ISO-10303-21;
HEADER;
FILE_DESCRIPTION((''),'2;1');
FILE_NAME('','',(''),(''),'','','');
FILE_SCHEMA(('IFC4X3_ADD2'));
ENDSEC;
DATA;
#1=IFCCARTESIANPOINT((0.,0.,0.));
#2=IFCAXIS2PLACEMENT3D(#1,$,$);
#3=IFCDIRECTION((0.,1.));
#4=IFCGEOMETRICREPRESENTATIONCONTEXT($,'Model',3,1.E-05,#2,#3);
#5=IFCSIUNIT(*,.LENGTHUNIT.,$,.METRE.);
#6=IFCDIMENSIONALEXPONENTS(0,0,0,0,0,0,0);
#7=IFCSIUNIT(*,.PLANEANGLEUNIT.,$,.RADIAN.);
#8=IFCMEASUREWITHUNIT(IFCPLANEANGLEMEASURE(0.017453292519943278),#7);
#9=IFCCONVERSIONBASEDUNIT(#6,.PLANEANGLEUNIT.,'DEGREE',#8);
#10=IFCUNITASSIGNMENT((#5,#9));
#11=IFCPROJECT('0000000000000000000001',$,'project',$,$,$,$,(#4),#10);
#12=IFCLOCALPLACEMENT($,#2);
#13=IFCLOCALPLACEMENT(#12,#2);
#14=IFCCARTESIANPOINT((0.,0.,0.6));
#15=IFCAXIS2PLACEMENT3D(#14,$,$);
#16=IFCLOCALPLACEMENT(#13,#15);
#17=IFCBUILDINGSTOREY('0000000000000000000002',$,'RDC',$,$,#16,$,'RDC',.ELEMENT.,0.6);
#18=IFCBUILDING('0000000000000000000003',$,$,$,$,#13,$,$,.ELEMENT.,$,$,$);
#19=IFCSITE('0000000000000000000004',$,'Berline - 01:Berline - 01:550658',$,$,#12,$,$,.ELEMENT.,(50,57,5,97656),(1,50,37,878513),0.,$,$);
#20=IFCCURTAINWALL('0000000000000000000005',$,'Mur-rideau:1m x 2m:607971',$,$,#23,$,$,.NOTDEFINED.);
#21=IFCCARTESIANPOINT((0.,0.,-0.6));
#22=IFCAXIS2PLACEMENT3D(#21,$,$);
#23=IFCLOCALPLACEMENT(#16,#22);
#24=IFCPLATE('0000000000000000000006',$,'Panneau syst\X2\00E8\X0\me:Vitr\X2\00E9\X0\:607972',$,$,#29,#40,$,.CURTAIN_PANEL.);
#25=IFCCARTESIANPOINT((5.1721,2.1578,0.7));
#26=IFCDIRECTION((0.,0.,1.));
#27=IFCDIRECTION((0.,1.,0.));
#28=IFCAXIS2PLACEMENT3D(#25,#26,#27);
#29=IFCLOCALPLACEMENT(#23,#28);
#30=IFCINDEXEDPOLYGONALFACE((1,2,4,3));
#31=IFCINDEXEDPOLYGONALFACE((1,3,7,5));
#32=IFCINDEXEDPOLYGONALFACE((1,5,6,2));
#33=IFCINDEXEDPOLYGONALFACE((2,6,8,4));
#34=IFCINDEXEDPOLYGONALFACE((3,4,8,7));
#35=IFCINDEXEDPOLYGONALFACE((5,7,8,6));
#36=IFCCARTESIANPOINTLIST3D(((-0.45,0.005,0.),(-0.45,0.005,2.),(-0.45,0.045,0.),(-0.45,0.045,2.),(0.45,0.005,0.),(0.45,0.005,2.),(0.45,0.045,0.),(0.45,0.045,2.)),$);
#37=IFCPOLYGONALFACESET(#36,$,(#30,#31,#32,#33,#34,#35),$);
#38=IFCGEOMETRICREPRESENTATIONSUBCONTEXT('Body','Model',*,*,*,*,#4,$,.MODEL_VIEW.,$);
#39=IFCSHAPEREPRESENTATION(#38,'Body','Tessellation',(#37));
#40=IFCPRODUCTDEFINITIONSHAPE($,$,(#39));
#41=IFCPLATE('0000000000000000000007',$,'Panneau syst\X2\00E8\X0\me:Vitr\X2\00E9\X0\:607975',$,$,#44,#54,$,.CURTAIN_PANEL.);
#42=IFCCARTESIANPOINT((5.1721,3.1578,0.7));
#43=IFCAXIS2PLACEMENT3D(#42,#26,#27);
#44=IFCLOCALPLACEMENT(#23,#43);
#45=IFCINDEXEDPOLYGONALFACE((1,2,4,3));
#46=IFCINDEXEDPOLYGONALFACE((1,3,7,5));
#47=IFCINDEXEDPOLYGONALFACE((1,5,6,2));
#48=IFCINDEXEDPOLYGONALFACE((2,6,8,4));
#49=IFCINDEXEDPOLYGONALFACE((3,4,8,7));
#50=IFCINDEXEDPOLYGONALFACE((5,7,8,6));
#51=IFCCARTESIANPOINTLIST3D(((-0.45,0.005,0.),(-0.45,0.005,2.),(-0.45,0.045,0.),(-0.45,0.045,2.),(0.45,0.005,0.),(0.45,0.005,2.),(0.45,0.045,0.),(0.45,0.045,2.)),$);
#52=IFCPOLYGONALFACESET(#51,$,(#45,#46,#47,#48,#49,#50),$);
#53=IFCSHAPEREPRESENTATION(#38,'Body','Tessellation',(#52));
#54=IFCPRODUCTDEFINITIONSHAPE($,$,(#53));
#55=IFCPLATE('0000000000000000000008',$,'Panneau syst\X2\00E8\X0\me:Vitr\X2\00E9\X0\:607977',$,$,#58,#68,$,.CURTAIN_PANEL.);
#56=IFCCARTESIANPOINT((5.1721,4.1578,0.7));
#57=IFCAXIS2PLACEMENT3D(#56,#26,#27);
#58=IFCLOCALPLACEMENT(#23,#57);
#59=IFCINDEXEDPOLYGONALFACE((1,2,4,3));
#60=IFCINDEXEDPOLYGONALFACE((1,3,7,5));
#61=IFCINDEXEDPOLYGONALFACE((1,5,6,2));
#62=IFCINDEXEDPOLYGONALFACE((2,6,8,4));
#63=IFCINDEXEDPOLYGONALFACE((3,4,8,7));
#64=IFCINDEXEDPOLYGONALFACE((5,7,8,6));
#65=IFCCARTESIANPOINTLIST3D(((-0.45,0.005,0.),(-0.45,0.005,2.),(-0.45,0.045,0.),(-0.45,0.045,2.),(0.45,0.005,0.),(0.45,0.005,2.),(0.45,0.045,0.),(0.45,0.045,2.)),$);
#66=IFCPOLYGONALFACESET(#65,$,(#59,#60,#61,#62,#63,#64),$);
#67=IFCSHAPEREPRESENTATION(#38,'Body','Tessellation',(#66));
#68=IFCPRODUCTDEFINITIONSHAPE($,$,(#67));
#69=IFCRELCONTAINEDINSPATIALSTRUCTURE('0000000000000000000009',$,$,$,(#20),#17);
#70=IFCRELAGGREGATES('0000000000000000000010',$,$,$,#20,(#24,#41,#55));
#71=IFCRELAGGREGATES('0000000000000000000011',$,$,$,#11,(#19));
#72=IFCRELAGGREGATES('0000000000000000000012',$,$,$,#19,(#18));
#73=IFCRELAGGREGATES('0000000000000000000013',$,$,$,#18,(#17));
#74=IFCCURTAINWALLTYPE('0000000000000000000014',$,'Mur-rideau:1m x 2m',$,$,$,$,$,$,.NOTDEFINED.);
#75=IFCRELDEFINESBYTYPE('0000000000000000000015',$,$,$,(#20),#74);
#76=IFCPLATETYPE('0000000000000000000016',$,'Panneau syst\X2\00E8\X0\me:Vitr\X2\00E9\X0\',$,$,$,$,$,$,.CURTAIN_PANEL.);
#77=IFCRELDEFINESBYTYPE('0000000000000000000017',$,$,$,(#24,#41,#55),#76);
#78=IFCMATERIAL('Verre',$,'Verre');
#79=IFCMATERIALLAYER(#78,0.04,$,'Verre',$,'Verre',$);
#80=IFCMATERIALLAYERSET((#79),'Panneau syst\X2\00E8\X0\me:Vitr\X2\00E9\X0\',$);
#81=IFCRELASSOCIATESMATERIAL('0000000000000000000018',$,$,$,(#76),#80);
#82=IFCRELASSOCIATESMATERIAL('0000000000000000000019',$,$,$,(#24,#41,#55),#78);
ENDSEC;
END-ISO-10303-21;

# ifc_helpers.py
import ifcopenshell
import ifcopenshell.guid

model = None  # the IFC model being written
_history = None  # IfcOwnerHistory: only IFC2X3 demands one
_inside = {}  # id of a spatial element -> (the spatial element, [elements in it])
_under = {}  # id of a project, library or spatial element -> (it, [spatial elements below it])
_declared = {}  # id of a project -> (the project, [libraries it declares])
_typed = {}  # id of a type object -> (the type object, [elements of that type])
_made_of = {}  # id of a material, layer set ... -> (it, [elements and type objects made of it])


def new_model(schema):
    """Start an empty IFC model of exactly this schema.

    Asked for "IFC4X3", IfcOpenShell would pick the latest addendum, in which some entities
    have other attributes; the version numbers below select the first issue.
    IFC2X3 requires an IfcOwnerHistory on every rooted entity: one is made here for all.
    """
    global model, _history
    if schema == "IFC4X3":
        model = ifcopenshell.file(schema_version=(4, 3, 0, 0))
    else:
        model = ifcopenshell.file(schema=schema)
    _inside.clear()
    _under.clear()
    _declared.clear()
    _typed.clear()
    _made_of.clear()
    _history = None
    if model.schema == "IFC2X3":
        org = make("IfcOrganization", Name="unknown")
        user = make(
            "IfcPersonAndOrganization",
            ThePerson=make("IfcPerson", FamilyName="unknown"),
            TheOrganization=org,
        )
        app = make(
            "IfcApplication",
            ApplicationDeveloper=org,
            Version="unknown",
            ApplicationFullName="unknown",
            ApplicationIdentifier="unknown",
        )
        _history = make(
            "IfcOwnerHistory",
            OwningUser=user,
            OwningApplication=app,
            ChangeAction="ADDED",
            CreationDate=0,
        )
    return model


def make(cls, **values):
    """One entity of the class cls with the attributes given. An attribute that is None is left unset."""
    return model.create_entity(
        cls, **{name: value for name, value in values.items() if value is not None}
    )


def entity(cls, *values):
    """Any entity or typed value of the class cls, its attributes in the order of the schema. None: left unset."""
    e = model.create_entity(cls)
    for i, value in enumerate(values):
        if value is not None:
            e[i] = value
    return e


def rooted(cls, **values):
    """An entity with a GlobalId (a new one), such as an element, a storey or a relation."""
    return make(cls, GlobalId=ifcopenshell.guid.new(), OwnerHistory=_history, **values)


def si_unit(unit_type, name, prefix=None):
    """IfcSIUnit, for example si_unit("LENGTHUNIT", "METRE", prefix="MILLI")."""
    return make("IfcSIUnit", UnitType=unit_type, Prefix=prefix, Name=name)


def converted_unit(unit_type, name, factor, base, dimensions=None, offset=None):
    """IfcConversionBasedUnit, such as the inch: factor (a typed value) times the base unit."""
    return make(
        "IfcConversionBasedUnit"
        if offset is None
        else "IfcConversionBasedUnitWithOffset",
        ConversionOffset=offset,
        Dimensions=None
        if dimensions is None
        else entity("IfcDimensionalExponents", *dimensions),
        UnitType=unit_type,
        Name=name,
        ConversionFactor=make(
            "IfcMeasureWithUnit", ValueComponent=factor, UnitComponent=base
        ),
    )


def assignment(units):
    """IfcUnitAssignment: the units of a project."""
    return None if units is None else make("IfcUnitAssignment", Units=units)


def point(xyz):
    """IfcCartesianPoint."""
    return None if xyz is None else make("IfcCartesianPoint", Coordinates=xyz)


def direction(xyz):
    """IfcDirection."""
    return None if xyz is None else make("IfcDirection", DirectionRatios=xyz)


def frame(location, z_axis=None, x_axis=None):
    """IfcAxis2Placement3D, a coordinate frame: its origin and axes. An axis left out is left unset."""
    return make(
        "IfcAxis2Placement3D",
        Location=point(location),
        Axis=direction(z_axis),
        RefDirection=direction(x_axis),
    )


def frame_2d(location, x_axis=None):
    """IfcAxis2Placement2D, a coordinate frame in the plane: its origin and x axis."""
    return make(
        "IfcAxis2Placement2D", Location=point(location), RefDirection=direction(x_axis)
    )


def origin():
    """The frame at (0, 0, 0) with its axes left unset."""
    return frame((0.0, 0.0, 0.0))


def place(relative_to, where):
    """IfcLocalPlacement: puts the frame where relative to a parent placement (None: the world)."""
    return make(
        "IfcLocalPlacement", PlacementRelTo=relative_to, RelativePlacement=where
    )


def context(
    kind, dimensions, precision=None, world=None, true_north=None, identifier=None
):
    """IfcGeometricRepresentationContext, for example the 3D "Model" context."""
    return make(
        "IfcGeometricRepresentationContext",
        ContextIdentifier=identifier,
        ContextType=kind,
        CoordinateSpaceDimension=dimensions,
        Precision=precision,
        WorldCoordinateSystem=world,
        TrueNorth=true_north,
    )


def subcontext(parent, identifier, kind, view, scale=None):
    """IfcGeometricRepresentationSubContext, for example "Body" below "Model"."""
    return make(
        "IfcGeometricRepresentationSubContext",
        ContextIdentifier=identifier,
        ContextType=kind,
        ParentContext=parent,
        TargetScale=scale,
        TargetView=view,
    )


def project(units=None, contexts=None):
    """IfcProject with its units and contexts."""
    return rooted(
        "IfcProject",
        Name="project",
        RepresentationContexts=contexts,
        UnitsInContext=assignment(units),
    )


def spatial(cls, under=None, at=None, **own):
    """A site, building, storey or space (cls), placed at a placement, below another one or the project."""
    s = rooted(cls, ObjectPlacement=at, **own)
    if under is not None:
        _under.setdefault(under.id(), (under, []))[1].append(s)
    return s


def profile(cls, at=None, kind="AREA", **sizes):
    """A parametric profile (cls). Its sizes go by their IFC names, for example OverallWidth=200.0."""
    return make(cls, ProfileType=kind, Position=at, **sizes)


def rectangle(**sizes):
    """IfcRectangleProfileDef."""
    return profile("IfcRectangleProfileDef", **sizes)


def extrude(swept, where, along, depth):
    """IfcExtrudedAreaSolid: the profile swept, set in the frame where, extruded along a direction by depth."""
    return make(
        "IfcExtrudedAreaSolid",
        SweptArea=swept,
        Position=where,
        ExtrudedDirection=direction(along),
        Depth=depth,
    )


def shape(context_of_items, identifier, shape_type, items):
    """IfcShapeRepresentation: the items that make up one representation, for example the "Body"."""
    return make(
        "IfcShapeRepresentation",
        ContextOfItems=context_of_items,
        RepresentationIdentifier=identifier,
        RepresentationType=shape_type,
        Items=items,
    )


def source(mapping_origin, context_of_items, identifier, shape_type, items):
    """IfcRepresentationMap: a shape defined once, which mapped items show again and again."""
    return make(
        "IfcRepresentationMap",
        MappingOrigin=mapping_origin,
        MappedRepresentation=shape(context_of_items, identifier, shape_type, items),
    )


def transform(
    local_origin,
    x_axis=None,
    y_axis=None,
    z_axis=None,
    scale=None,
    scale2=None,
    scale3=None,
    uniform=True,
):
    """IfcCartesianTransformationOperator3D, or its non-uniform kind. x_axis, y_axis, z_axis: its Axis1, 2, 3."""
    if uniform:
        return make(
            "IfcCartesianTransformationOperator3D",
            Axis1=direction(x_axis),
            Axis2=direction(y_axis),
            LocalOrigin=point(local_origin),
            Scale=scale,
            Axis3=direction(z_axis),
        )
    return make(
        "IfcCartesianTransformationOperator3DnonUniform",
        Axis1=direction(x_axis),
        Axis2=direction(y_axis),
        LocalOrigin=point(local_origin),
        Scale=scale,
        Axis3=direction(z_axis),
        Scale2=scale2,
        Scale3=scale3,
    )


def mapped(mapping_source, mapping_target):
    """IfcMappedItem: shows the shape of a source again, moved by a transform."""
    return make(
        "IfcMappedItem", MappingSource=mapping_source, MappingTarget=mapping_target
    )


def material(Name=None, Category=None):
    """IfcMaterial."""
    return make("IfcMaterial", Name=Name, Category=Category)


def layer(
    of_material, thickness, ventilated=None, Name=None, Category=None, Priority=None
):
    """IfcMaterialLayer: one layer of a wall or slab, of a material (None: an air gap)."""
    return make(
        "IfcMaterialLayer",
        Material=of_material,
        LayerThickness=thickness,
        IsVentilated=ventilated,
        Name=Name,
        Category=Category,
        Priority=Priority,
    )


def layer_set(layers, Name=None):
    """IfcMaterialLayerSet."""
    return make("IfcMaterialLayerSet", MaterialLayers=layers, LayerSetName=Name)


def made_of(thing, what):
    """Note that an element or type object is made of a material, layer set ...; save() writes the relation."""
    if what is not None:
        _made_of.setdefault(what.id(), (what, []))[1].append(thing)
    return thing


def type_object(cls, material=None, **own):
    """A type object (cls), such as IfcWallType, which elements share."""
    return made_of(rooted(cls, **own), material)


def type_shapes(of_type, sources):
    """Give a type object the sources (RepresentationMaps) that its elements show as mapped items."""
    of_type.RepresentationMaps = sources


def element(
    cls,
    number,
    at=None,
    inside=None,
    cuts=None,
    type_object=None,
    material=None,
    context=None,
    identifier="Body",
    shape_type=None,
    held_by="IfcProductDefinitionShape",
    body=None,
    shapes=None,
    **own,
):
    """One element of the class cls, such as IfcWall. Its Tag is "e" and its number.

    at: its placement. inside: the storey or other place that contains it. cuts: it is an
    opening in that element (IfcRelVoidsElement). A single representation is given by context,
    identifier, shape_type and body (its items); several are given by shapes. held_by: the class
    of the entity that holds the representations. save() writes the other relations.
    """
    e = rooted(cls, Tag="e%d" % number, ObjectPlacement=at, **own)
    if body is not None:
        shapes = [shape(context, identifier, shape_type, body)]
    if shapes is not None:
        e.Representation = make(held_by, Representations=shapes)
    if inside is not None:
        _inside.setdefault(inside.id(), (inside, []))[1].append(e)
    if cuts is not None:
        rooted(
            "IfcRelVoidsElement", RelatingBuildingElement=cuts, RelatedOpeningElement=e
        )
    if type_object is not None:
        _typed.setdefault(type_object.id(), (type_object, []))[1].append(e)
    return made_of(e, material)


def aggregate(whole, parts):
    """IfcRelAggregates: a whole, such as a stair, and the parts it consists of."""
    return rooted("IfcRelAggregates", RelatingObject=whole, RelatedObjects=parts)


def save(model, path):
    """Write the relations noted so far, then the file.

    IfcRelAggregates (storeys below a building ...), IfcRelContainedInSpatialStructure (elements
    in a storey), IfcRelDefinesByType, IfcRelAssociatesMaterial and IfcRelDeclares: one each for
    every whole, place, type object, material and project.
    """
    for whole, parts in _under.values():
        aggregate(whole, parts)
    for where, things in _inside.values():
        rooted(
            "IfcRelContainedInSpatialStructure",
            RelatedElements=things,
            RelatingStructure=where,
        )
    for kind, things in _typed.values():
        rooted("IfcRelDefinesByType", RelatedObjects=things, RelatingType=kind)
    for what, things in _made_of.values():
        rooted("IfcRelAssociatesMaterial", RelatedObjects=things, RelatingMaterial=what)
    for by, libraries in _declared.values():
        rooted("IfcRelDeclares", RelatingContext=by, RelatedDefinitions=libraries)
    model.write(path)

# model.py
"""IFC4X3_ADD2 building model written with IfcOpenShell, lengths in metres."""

from ifc_helpers import new_model, entity, si_unit, converted_unit, direction, frame, frame_2d, origin, place, context, subcontext, project, spatial, rectangle, extrude, source, transform, mapped, material, layer, layer_set, type_object, type_shapes, element, aggregate, save


model = new_model("IFC4X3_ADD2")

# Units and contexts
model_context = context("Model", 3, precision=1e-05, world=origin(), true_north=direction((0.0, 1.0)))
body_context = subcontext(model_context, "Body", "Model", "MODEL_VIEW")
ifc_project = project(units=[si_unit("LENGTHUNIT", "METRE"), converted_unit("PLANEANGLEUNIT", "DEGREE", entity("IfcPlaneAngleMeasure", 0.017453292519943278), si_unit("PLANEANGLEUNIT", "RADIAN"), dimensions=[0, 0, 0, 0, 0, 0, 0])], contexts=[model_context])

# Site, building, storey
site_placement = place(None, origin())
site = spatial("IfcSite", under=ifc_project, at=site_placement, Name="Berline - 01:Berline - 01:550658", CompositionType="ELEMENT", RefLatitude=(50, 57, 5, 97656), RefLongitude=(1, 50, 37, 878513), RefElevation=0.0)
building_placement = place(site_placement, origin())
building = spatial("IfcBuilding", under=site, at=building_placement, CompositionType="ELEMENT")
storey_placement = place(building_placement, frame((0.0, 0.0, 0.6)))
storey = spatial("IfcBuildingStorey", under=building, at=storey_placement, Name="RDC", LongName="RDC", CompositionType="ELEMENT", Elevation=0.6)

# Curtain wall
curtain_wall_type = type_object("IfcCurtainWallType", Name="Mur-rideau:1m x 2m", PredefinedType="NOTDEFINED")
curtain_wall_placement = place(storey_placement, frame((0.0, 0.0, -0.6)))
curtain_wall = element("IfcCurtainWall", 1, at=curtain_wall_placement, inside=storey, type_object=curtain_wall_type, Name="Mur-rideau:1m x 2m:607971", PredefinedType="NOTDEFINED")

# Plates
ifc_material_1 = material(Name="Verre", Category="Verre")
ifc_layer_1 = layer(ifc_material_1, 0.04, Name="Verre", Category="Verre")
ifc_layer_set_1 = layer_set([ifc_layer_1], Name="Panneau système:Vitré")
plate_type = type_object("IfcPlateType", Name="Panneau système:Vitré", PredefinedType="CURTAIN_PANEL", material=ifc_layer_set_1)
shared_shape_1 = source(origin(), body_context, "Body", "SweptSolid", [
    extrude(rectangle(XDim=0.04, YDim=0.9, at=frame_2d((0.0, 0.0), x_axis=(1.0, 0.0))), frame((0.0, 0.025, 0.0), z_axis=(0.0, 0.0, 1.0), x_axis=(0.0, 1.0, 0.0)), (0.0, 0.0, 1.0), 2.0),
])
type_shapes(plate_type, [shared_shape_1])
plate_1_placement = place(curtain_wall_placement, frame((5.1721, 2.1578, 0.7), z_axis=(0.0, 0.0, 1.0), x_axis=(0.0, 1.0, 0.0)))
plate_1 = element("IfcPlate", 2, at=plate_1_placement, type_object=plate_type, material=ifc_material_1, Name="Panneau système:Vitré:607972", PredefinedType="CURTAIN_PANEL", context=body_context, shape_type="MappedRepresentation", body=[
    mapped(shared_shape_1, transform((0.0, 0.0, 0.0), scale=1.0)),
])
plate_2_placement = place(curtain_wall_placement, frame((5.1721, 3.1578, 0.7), z_axis=(0.0, 0.0, 1.0), x_axis=(0.0, 1.0, 0.0)))
plate_2 = element("IfcPlate", 3, at=plate_2_placement, type_object=plate_type, material=ifc_material_1, Name="Panneau système:Vitré:607975", PredefinedType="CURTAIN_PANEL", context=body_context, shape_type="MappedRepresentation", body=[
    mapped(shared_shape_1, transform((0.0, 0.0, 0.0), scale=1.0)),
])
plate_3_placement = place(curtain_wall_placement, frame((5.1721, 4.1578, 0.7), z_axis=(0.0, 0.0, 1.0), x_axis=(0.0, 1.0, 0.0)))
plate_3 = element("IfcPlate", 4, at=plate_3_placement, type_object=plate_type, material=ifc_material_1, Name="Panneau système:Vitré:607977", PredefinedType="CURTAIN_PANEL", context=body_context, shape_type="MappedRepresentation", body=[
    mapped(shared_shape_1, transform((0.0, 0.0, 0.0), scale=1.0)),
])
aggregate(curtain_wall, [plate_1, plate_2, plate_3])

save(model, "model.ifc")
